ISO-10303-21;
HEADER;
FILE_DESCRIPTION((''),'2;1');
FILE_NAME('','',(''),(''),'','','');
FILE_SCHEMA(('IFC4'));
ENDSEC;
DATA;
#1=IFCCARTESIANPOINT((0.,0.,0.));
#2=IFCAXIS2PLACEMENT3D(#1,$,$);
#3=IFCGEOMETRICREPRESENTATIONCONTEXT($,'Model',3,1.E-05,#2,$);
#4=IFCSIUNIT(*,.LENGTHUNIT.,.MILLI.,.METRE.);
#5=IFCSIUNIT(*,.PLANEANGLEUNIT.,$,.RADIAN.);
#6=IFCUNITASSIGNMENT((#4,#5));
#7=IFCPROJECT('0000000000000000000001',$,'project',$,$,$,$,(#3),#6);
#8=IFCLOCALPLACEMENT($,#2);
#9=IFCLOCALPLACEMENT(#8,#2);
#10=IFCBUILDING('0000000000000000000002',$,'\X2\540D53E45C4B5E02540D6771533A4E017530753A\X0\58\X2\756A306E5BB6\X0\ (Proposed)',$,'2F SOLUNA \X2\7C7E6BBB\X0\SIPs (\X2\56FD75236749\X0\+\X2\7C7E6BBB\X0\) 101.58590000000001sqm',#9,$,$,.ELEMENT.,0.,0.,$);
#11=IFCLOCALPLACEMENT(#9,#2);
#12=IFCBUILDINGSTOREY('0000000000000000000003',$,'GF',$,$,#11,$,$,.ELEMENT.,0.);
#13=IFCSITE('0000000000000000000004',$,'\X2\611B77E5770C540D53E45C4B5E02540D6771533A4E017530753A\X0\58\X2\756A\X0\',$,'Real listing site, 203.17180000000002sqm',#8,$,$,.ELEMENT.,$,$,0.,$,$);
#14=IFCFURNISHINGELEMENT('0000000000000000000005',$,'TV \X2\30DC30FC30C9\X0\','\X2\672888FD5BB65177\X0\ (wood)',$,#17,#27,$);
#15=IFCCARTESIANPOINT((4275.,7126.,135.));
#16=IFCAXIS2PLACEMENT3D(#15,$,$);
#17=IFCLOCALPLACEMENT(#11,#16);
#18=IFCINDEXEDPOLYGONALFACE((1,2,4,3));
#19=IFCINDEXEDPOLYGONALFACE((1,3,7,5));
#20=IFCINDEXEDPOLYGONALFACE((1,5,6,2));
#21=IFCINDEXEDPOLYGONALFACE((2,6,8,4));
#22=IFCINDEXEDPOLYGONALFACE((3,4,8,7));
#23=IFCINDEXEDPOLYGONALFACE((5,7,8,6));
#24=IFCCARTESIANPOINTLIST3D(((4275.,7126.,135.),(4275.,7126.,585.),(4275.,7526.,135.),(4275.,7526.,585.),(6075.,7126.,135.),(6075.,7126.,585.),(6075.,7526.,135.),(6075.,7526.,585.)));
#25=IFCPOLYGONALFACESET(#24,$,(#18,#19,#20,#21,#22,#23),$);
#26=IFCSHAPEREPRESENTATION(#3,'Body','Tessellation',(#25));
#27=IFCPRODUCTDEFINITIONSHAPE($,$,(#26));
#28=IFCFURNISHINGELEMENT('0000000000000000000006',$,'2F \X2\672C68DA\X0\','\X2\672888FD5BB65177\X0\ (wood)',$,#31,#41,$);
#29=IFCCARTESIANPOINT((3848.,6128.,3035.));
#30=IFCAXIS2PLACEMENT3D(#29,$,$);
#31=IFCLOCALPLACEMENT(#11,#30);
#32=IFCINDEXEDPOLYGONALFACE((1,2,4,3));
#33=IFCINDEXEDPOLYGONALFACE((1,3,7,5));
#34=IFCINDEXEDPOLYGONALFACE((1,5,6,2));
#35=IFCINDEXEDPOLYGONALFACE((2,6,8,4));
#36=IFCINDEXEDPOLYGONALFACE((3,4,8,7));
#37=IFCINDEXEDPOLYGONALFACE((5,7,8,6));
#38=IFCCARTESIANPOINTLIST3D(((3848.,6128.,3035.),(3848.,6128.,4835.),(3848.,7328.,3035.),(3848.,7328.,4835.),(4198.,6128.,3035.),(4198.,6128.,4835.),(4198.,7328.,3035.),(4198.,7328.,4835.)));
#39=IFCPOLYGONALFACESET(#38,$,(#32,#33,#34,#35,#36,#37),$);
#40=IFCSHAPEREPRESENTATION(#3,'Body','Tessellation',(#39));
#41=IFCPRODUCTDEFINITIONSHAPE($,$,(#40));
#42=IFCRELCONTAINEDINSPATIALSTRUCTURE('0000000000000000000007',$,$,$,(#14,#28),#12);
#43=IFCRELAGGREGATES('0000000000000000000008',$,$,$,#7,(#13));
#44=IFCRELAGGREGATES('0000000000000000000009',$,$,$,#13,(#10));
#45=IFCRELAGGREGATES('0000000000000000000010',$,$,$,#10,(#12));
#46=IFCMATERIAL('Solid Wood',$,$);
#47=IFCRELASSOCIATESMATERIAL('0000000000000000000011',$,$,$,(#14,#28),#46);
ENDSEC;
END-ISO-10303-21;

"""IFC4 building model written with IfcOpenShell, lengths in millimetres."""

from ifc_helpers import new_model, si_unit, frame, frame_2d, origin, place, context, project, spatial, rectangle, extrude, material, element, save


model = new_model("IFC4")

# Units and contexts
model_context = context("Model", 3, precision=1e-05, world=origin())
ifc_project = project(units=[si_unit("LENGTHUNIT", "METRE", prefix="MILLI"), si_unit("PLANEANGLEUNIT", "RADIAN")], contexts=[model_context])

# Site, building, storey
site_placement = place(None, origin())
site = spatial("IfcSite", under=ifc_project, at=site_placement, Name="愛知県名古屋市名東区丁田町58番", ObjectType="Real listing site, 203.17180000000002sqm", CompositionType="ELEMENT", RefElevation=0.0)
building_placement = place(site_placement, origin())
building = spatial("IfcBuilding", under=site, at=building_placement, Name="名古屋市名東区丁田町58番の家 (Proposed)", ObjectType="2F SOLUNA 籾殻SIPs (国産杉+籾殻) 101.58590000000001sqm", CompositionType="ELEMENT", ElevationOfRefHeight=0.0, ElevationOfTerrain=0.0)
storey_placement = place(building_placement, origin())
storey = spatial("IfcBuildingStorey", under=building, at=storey_placement, Name="GF", CompositionType="ELEMENT", Elevation=0.0)

# Shared definitions
ifc_material_1 = material(Name="Solid Wood")

# Furnishing elements
furnishing_1_placement = place(storey_placement, frame((4275.0, 7126.0, 135.0)))
element("IfcFurnishingElement", 1, at=furnishing_1_placement, inside=storey, material=ifc_material_1, Name="TV ボード", Description="木製家具 (wood)", context=model_context, shape_type="SweptSolid", body=[
    extrude(rectangle(XDim=1800.0, YDim=400.0, at=frame_2d((900.0, 200.0))), frame((4275.0, 7126.0, 135.0)), (0.0, 0.0, 1.0), 450.0),
])
furnishing_2_placement = place(storey_placement, frame((3848.0, 6128.0, 3035.0)))
element("IfcFurnishingElement", 2, at=furnishing_2_placement, inside=storey, material=ifc_material_1, Name="2F 本棚", Description="木製家具 (wood)", context=model_context, shape_type="SweptSolid", body=[
    extrude(rectangle(XDim=350.0, YDim=1200.0, at=frame_2d((175.0, 600.0))), frame((3848.0, 6128.0, 3035.0)), (0.0, 0.0, 1.0), 1800.0),
])

save(model, "model.ifc")
